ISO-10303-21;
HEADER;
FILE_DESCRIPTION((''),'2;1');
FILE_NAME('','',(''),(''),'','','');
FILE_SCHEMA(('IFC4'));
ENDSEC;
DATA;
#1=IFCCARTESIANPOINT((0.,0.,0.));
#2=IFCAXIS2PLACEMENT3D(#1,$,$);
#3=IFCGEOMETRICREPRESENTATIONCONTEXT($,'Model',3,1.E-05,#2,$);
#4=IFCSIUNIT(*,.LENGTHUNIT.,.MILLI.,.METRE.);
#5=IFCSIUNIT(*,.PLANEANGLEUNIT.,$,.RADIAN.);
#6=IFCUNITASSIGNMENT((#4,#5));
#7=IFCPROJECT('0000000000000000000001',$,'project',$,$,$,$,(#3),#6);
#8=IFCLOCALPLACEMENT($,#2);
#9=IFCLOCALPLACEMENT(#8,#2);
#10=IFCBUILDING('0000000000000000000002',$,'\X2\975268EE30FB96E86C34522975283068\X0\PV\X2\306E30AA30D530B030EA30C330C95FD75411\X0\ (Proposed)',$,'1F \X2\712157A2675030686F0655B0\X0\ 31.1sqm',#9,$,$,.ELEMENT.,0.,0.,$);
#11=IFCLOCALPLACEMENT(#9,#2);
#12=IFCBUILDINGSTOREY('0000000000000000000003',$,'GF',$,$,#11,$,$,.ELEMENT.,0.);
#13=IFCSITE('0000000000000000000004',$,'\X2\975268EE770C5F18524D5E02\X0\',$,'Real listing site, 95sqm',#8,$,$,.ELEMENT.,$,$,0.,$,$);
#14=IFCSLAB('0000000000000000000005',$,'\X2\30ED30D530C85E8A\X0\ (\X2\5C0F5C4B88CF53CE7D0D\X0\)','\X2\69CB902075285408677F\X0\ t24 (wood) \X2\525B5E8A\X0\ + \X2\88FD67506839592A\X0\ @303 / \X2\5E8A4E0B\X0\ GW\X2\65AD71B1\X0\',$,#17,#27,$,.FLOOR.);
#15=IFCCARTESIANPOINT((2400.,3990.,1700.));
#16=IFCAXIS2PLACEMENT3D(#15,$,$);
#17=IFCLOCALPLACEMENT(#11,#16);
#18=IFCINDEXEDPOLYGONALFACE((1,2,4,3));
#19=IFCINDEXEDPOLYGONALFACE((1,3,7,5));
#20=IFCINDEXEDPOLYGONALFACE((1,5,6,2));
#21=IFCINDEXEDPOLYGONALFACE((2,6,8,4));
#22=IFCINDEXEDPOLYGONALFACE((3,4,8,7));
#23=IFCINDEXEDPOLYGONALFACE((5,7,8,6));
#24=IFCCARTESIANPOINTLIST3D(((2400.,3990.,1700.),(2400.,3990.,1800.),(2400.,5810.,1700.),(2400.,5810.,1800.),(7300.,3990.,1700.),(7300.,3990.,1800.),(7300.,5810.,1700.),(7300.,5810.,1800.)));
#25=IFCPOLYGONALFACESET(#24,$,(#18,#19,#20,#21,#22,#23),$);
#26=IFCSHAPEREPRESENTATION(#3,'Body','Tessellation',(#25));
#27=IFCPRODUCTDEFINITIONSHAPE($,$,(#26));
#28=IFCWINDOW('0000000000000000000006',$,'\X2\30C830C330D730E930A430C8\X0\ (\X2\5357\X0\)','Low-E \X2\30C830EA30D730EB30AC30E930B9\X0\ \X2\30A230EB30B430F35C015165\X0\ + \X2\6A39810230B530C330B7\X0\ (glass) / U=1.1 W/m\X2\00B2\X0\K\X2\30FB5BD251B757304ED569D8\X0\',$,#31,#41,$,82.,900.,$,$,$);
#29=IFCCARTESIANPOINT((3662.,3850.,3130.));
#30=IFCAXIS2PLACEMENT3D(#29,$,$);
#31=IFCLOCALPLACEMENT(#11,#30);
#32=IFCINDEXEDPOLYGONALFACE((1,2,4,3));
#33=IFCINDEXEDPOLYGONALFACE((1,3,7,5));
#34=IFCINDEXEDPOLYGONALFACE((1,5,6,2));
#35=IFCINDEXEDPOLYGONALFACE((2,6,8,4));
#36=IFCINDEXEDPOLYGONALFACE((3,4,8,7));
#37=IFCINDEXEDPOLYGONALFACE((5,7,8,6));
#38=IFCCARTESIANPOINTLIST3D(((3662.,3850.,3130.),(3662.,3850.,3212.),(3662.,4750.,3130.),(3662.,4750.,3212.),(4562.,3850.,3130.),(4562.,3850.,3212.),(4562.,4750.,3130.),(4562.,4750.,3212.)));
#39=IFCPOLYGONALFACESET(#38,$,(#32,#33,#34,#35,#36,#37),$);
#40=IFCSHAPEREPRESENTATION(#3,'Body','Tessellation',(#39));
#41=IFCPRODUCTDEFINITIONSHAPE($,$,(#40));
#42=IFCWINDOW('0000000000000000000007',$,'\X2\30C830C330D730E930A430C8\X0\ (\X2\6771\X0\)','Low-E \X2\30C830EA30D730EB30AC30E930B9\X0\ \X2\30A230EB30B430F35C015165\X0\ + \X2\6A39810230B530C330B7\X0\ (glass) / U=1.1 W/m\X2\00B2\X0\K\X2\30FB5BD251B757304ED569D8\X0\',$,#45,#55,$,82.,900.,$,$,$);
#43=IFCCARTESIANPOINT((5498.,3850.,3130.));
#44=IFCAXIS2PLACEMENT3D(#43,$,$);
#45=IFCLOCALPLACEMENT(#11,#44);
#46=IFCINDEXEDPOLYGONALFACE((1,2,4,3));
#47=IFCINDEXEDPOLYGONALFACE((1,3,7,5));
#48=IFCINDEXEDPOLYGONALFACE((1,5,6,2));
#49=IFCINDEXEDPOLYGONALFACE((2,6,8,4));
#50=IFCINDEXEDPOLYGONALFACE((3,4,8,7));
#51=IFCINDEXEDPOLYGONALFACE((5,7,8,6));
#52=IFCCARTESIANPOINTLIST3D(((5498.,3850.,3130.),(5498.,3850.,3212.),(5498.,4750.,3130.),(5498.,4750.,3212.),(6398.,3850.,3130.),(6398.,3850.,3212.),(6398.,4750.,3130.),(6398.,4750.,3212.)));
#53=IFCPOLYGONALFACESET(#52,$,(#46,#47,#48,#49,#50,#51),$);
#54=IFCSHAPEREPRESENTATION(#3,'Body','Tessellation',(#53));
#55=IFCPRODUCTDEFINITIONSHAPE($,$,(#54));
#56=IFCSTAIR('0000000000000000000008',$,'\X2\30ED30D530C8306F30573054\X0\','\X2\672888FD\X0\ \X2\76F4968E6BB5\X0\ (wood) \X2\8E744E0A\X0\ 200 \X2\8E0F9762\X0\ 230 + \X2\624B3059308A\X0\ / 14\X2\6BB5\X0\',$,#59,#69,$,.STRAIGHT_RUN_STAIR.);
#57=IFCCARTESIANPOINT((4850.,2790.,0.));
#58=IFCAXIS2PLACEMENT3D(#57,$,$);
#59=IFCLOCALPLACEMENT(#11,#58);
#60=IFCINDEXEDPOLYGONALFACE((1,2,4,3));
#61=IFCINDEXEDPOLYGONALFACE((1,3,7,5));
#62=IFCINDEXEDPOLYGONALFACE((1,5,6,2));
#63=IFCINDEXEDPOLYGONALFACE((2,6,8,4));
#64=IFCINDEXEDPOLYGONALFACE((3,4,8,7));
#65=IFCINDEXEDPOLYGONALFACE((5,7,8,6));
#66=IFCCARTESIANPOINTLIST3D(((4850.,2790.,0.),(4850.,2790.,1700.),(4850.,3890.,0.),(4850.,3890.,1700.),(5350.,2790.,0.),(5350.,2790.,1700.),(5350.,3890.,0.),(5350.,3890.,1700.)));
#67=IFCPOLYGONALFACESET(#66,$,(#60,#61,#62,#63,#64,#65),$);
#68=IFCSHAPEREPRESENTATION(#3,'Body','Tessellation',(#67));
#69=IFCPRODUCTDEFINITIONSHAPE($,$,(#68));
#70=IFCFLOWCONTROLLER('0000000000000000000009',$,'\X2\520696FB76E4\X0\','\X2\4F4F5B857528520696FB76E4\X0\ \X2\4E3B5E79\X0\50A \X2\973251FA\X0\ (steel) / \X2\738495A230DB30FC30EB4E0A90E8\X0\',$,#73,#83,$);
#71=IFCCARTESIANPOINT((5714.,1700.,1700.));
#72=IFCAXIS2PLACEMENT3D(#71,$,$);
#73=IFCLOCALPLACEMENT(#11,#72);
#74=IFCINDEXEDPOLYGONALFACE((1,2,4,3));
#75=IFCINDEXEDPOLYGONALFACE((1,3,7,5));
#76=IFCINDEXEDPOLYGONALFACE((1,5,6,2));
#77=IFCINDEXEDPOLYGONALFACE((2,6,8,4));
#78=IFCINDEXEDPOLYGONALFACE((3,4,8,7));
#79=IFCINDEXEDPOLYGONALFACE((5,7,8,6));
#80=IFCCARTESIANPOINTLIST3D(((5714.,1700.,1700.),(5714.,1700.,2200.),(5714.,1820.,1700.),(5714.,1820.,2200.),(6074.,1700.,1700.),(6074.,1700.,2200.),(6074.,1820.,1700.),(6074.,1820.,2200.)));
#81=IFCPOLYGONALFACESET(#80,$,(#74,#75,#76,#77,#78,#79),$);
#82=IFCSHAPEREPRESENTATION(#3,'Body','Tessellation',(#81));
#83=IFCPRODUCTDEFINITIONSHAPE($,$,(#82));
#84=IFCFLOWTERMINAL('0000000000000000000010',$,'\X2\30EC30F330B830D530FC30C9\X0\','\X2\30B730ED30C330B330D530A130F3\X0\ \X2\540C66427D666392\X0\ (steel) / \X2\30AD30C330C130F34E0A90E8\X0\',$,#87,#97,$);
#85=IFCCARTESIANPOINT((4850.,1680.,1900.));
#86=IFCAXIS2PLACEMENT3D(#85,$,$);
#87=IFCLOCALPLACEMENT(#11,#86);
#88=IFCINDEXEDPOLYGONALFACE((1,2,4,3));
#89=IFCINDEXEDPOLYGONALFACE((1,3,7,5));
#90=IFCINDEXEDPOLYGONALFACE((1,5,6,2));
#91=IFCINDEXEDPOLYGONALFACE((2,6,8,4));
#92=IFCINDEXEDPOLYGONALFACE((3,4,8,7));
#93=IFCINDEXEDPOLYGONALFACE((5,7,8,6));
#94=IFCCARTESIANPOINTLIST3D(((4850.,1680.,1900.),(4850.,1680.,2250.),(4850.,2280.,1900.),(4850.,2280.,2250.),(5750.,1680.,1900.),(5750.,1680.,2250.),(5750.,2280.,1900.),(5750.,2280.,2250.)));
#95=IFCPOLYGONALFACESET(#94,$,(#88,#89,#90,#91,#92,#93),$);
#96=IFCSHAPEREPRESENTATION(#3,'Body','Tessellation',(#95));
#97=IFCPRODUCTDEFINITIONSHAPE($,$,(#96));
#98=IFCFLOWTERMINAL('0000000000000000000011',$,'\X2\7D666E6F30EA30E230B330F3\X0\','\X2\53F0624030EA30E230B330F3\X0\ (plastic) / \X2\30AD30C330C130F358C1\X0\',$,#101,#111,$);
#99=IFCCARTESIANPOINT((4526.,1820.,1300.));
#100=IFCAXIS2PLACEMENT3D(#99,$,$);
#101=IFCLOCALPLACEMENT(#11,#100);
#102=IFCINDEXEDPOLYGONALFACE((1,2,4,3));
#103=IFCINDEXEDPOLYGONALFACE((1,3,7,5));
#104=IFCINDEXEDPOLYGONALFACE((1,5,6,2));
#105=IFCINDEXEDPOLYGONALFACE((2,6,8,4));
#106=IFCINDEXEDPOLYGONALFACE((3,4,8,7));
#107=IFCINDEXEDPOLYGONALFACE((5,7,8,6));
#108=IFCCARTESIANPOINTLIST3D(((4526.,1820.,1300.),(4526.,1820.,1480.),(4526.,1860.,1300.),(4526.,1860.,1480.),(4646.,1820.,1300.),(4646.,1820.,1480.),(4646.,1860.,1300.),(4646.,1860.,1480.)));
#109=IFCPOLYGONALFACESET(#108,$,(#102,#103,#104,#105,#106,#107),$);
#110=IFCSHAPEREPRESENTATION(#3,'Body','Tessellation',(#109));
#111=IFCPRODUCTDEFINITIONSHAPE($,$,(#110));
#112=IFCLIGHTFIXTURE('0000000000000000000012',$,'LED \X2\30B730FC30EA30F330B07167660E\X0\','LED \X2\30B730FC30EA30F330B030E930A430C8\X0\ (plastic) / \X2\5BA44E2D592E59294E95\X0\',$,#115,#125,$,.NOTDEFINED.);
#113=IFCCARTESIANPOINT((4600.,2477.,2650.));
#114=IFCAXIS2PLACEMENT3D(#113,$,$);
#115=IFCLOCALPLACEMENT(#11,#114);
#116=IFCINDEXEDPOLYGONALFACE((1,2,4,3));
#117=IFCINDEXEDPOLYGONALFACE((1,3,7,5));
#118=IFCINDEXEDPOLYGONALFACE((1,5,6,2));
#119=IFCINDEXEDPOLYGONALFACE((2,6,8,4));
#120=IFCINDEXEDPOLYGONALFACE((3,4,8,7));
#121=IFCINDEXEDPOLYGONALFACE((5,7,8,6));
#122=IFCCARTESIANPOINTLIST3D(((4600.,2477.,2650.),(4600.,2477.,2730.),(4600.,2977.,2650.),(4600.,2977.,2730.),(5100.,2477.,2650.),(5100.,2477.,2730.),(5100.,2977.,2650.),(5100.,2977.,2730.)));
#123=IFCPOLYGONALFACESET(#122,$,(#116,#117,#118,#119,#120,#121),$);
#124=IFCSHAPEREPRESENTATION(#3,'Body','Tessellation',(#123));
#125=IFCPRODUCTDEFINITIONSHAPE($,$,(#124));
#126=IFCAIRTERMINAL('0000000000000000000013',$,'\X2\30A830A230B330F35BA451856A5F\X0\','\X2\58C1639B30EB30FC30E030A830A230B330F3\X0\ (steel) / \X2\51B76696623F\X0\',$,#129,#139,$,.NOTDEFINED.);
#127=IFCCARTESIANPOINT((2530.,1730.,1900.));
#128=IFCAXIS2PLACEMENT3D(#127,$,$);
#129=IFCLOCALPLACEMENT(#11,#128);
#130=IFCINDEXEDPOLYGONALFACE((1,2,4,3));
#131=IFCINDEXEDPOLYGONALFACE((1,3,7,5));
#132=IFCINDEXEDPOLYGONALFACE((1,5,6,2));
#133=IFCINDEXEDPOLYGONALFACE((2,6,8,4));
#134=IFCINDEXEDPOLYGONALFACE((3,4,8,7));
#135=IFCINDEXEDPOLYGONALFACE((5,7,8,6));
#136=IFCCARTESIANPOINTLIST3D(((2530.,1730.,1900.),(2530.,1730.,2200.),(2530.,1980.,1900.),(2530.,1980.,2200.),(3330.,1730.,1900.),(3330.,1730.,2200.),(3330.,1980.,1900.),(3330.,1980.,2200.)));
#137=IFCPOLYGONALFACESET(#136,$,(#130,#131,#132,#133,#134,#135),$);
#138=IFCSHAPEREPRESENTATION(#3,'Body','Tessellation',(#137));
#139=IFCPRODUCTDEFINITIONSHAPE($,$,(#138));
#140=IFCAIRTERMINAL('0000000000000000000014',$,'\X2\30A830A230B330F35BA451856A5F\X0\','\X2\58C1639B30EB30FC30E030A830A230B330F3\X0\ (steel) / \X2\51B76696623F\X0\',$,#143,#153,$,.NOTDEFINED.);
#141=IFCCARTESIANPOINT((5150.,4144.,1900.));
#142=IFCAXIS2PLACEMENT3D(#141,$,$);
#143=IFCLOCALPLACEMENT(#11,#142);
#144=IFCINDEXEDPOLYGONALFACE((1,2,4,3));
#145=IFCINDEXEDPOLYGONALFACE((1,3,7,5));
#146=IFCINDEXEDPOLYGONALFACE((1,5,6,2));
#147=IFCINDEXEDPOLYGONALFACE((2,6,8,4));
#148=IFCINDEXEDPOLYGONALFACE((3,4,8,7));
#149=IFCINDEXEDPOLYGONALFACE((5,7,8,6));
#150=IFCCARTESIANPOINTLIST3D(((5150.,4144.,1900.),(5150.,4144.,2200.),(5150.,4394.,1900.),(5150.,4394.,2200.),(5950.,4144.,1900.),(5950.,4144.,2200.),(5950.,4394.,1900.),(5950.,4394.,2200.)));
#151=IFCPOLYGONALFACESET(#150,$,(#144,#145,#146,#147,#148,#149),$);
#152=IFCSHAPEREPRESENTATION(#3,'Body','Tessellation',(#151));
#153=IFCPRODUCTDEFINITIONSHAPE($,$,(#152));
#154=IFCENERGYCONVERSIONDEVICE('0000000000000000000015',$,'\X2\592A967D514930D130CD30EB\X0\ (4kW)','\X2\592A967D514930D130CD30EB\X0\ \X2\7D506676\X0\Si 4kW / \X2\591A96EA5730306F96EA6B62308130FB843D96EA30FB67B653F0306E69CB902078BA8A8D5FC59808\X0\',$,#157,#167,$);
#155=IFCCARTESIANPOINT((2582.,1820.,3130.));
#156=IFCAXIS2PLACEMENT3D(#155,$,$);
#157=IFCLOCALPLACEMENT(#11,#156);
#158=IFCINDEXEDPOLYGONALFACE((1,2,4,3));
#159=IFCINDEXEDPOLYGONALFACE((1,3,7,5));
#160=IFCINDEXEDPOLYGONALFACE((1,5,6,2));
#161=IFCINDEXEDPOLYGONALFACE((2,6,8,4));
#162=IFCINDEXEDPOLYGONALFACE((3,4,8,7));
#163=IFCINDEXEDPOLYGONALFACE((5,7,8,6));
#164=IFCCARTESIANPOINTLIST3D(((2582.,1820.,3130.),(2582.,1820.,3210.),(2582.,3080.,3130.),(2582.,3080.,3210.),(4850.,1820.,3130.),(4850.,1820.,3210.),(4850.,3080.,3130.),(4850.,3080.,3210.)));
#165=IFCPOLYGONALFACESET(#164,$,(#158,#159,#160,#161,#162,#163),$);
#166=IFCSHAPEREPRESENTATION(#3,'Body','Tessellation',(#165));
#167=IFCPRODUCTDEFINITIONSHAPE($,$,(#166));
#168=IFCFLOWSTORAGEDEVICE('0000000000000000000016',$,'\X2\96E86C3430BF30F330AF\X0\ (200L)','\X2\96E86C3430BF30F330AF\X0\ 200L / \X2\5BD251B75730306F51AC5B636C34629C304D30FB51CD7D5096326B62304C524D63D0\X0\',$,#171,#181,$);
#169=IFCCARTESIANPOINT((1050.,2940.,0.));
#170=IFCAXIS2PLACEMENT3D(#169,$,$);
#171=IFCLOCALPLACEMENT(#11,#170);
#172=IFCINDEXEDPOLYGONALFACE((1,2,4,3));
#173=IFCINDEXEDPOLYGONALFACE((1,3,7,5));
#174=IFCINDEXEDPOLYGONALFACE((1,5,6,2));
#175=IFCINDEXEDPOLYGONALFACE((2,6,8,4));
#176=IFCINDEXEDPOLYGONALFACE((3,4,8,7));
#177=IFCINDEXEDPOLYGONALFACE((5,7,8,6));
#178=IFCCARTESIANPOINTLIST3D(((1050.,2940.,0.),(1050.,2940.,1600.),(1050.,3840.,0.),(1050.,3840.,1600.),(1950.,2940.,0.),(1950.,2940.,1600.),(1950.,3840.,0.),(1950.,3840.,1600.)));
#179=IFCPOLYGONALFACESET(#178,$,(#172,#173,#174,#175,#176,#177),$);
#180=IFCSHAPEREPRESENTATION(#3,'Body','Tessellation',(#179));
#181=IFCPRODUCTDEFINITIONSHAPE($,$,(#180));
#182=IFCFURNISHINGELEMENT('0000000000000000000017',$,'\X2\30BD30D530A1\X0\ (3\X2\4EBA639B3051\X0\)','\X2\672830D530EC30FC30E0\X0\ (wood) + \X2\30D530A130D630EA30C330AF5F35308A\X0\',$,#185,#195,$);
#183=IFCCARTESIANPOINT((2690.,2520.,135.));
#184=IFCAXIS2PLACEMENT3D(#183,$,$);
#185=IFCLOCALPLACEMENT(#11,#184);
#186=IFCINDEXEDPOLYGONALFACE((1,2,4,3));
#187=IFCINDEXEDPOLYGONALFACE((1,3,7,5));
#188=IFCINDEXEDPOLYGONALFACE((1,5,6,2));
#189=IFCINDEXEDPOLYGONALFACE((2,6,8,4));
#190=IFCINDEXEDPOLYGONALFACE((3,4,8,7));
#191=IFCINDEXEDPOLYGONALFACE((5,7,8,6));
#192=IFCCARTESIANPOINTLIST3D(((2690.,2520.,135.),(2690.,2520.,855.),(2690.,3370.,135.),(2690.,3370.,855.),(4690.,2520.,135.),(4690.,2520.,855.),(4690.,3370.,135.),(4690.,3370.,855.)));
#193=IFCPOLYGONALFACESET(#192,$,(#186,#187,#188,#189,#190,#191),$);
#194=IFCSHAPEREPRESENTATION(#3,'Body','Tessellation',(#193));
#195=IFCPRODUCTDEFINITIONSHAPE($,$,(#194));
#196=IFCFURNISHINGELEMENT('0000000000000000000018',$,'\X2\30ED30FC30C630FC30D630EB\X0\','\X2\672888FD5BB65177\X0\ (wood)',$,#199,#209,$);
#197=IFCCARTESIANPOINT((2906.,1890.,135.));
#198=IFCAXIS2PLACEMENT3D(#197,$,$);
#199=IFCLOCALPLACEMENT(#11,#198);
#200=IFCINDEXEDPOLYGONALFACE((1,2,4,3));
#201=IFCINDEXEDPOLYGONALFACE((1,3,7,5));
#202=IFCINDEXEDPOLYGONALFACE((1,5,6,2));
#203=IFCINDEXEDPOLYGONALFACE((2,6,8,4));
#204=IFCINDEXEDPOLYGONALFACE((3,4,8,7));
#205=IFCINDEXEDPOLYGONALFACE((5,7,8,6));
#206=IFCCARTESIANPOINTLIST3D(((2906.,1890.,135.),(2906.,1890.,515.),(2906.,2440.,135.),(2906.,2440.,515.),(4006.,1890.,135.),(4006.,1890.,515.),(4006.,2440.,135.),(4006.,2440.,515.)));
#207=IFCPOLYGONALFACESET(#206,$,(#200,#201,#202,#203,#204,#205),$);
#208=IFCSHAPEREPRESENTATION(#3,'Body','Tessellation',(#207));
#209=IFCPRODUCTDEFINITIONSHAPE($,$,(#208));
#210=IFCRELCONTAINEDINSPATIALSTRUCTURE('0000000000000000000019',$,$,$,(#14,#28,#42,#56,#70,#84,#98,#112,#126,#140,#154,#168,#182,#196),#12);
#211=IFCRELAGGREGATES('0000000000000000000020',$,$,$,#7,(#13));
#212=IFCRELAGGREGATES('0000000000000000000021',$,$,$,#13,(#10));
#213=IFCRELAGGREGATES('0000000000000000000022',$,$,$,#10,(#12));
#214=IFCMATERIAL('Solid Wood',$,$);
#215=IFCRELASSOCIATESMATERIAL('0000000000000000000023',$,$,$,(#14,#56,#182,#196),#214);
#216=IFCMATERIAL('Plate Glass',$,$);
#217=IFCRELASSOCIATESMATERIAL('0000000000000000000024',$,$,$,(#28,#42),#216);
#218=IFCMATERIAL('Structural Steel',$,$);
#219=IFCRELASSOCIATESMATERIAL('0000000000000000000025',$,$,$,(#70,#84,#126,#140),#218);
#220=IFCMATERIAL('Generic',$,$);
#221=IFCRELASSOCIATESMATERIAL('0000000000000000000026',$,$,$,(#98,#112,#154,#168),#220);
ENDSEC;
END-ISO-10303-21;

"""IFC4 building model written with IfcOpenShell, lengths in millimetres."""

from ifc_helpers import new_model, si_unit, frame, frame_2d, origin, place, context, project, spatial, rectangle, extrude, material, element, save


model = new_model("IFC4")

# Units and contexts
model_context = context("Model", 3, precision=1e-05, world=origin())
ifc_project = project(units=[si_unit("LENGTHUNIT", "METRE", prefix="MILLI"), si_unit("PLANEANGLEUNIT", "RADIAN")], contexts=[model_context])

# Site, building, storey
site_placement = place(None, origin())
site = spatial("IfcSite", under=ifc_project, at=site_placement, Name="青森県弘前市", ObjectType="Real listing site, 95sqm", CompositionType="ELEMENT", RefElevation=0.0)
building_placement = place(site_placement, origin())
building = spatial("IfcBuilding", under=site, at=building_placement, Name="青森・雨水利用とPVのオフグリッド志向 (Proposed)", ObjectType="1F 無垢材と漆喰 31.1sqm", CompositionType="ELEMENT", ElevationOfRefHeight=0.0, ElevationOfTerrain=0.0)
storey_placement = place(building_placement, origin())
storey = spatial("IfcBuildingStorey", under=building, at=storey_placement, Name="GF", CompositionType="ELEMENT", Elevation=0.0)

# Shared definitions
ifc_material_1 = material(Name="Solid Wood")

# Slab
slab_placement = place(storey_placement, frame((2400.0, 3990.0, 1700.0)))
element("IfcSlab", 1, at=slab_placement, inside=storey, material=ifc_material_1, Name="ロフト床 (小屋裏収納)", Description="構造用合板 t24 (wood) 剛床 + 製材根太 @303 / 床下 GW断熱", PredefinedType="FLOOR", context=model_context, shape_type="SweptSolid", body=[
    extrude(rectangle(XDim=4900.0, YDim=1820.0, at=frame_2d((2450.0, 910.0))), frame((2400.0, 3990.0, 1700.0)), (0.0, 0.0, 1.0), 100.0),
])

# Windows
ifc_material_2 = material(Name="Plate Glass")
window_1_placement = place(storey_placement, frame((3662.0, 3850.0, 3130.0)))
element("IfcWindow", 2, at=window_1_placement, inside=storey, material=ifc_material_2, Name="トップライト (南)", Description="Low-E トリプルガラス アルゴン封入 + 樹脂サッシ (glass) / U=1.1 W/m²K・寒冷地仕様", OverallHeight=82.0, OverallWidth=900.0, context=model_context, shape_type="SweptSolid", body=[
    extrude(rectangle(XDim=900.0, YDim=900.0, at=frame_2d((450.0, 450.0))), frame((3662.0, 3850.0, 3130.0)), (0.0, 0.0, 1.0), 82.0),
])
window_2_placement = place(storey_placement, frame((5498.0, 3850.0, 3130.0)))
element("IfcWindow", 3, at=window_2_placement, inside=storey, material=ifc_material_2, Name="トップライト (東)", Description="Low-E トリプルガラス アルゴン封入 + 樹脂サッシ (glass) / U=1.1 W/m²K・寒冷地仕様", OverallHeight=82.0, OverallWidth=900.0, context=model_context, shape_type="SweptSolid", body=[
    extrude(rectangle(XDim=900.0, YDim=900.0, at=frame_2d((450.0, 450.0))), frame((5498.0, 3850.0, 3130.0)), (0.0, 0.0, 1.0), 82.0),
])

# Stair
stair_placement = place(storey_placement, frame((4850.0, 2790.0, 0.0)))
element("IfcStair", 4, at=stair_placement, inside=storey, material=ifc_material_1, Name="ロフトはしご", Description="木製 直階段 (wood) 蹴上 200 踏面 230 + 手すり / 14段", PredefinedType="STRAIGHT_RUN_STAIR", context=model_context, shape_type="SweptSolid", body=[
    extrude(rectangle(XDim=500.0, YDim=1100.0, at=frame_2d((250.0, 550.0))), frame((4850.0, 2790.0, 0.0)), (0.0, 0.0, 1.0), 1700.0),
])

# Flow controller
ifc_material_3 = material(Name="Structural Steel")
flow_controller_placement = place(storey_placement, frame((5714.0, 1700.0, 1700.0)))
element("IfcFlowController", 5, at=flow_controller_placement, inside=storey, material=ifc_material_3, Name="分電盤", Description="住宅用分電盤 主幹50A 露出 (steel) / 玄関ホール上部", context=model_context, shape_type="SweptSolid", body=[
    extrude(rectangle(XDim=360.0, YDim=120.0, at=frame_2d((180.0, 60.0))), frame((5714.0, 1700.0, 1700.0)), (0.0, 0.0, 1.0), 500.0),
])

# Flow terminals
flow_terminal_1_placement = place(storey_placement, frame((4850.0, 1680.0, 1900.0)))
element("IfcFlowTerminal", 6, at=flow_terminal_1_placement, inside=storey, material=ifc_material_3, Name="レンジフード", Description="シロッコファン 同時給排 (steel) / キッチン上部", context=model_context, shape_type="SweptSolid", body=[
    extrude(rectangle(XDim=900.0, YDim=600.0, at=frame_2d((450.0, 300.0))), frame((4850.0, 1680.0, 1900.0)), (0.0, 0.0, 1.0), 350.0),
])
ifc_material_4 = material(Name="Generic")
flow_terminal_2_placement = place(storey_placement, frame((4526.0, 1820.0, 1300.0)))
element("IfcFlowTerminal", 7, at=flow_terminal_2_placement, inside=storey, material=ifc_material_4, Name="給湯リモコン", Description="台所リモコン (plastic) / キッチン壁", context=model_context, shape_type="SweptSolid", body=[
    extrude(rectangle(XDim=120.0, YDim=40.0, at=frame_2d((60.0, 20.0))), frame((4526.0, 1820.0, 1300.0)), (0.0, 0.0, 1.0), 180.0),
])

# Light fixture
light_fixture_placement = place(storey_placement, frame((4600.0, 2477.0, 2650.0)))
element("IfcLightFixture", 8, at=light_fixture_placement, inside=storey, material=ifc_material_4, Name="LED シーリング照明", Description="LED シーリングライト (plastic) / 室中央天井", PredefinedType="NOTDEFINED", context=model_context, shape_type="SweptSolid", body=[
    extrude(rectangle(XDim=500.0, YDim=500.0, at=frame_2d((250.0, 250.0))), frame((4600.0, 2477.0, 2650.0)), (0.0, 0.0, 1.0), 80.0),
])

# Air terminals
air_terminal_1_placement = place(storey_placement, frame((2530.0, 1730.0, 1900.0)))
element("IfcAirTerminal", 9, at=air_terminal_1_placement, inside=storey, material=ifc_material_3, Name="エアコン室内機", Description="壁掛ルームエアコン (steel) / 冷暖房", PredefinedType="NOTDEFINED", context=model_context, shape_type="SweptSolid", body=[
    extrude(rectangle(XDim=800.0, YDim=250.0, at=frame_2d((400.0, 125.0))), frame((2530.0, 1730.0, 1900.0)), (0.0, 0.0, 1.0), 300.0),
])
air_terminal_2_placement = place(storey_placement, frame((5150.0, 4144.0, 1900.0)))
element("IfcAirTerminal", 10, at=air_terminal_2_placement, inside=storey, material=ifc_material_3, Name="エアコン室内機", Description="壁掛ルームエアコン (steel) / 冷暖房", PredefinedType="NOTDEFINED", context=model_context, shape_type="SweptSolid", body=[
    extrude(rectangle(XDim=800.0, YDim=250.0, at=frame_2d((400.0, 125.0))), frame((5150.0, 4144.0, 1900.0)), (0.0, 0.0, 1.0), 300.0),
])

# Energy conversion device
energy_conversion_device_placement = place(storey_placement, frame((2582.0, 1820.0, 3130.0)))
element("IfcEnergyConversionDevice", 11, at=energy_conversion_device_placement, inside=storey, material=ifc_material_4, Name="太陽光パネル (4kW)", Description="太陽光パネル 結晶Si 4kW / 多雪地は雪止め・落雪・架台の構造確認必須", context=model_context, shape_type="SweptSolid", body=[
    extrude(rectangle(XDim=2268.0, YDim=1260.0, at=frame_2d((1134.0, 630.0))), frame((2582.0, 1820.0, 3130.0)), (0.0, 0.0, 1.0), 80.0),
])

# Flow storage device
flow_storage_device_placement = place(storey_placement, frame((1050.0, 2940.0, 0.0)))
element("IfcFlowStorageDevice", 12, at=flow_storage_device_placement, inside=storey, material=ifc_material_4, Name="雨水タンク (200L)", Description="雨水タンク 200L / 寒冷地は冬季水抜き・凍結防止が前提", context=model_context, shape_type="SweptSolid", body=[
    extrude(rectangle(XDim=900.0, YDim=900.0, at=frame_2d((450.0, 450.0))), frame((1050.0, 2940.0, 0.0)), (0.0, 0.0, 1.0), 1600.0),
])

# Furnishing elements
furnishing_1_placement = place(storey_placement, frame((2690.0, 2520.0, 135.0)))
element("IfcFurnishingElement", 13, at=furnishing_1_placement, inside=storey, material=ifc_material_1, Name="ソファ (3人掛け)", Description="木フレーム (wood) + ファブリック張り", context=model_context, shape_type="SweptSolid", body=[
    extrude(rectangle(XDim=2000.0, YDim=850.0, at=frame_2d((1000.0, 425.0))), frame((2690.0, 2520.0, 135.0)), (0.0, 0.0, 1.0), 720.0),
])
furnishing_2_placement = place(storey_placement, frame((2906.0, 1890.0, 135.0)))
element("IfcFurnishingElement", 14, at=furnishing_2_placement, inside=storey, material=ifc_material_1, Name="ローテーブル", Description="木製家具 (wood)", context=model_context, shape_type="SweptSolid", body=[
    extrude(rectangle(XDim=1100.0, YDim=550.0, at=frame_2d((550.0, 275.0))), frame((2906.0, 1890.0, 135.0)), (0.0, 0.0, 1.0), 380.0),
])

save(model, "model.ifc")
